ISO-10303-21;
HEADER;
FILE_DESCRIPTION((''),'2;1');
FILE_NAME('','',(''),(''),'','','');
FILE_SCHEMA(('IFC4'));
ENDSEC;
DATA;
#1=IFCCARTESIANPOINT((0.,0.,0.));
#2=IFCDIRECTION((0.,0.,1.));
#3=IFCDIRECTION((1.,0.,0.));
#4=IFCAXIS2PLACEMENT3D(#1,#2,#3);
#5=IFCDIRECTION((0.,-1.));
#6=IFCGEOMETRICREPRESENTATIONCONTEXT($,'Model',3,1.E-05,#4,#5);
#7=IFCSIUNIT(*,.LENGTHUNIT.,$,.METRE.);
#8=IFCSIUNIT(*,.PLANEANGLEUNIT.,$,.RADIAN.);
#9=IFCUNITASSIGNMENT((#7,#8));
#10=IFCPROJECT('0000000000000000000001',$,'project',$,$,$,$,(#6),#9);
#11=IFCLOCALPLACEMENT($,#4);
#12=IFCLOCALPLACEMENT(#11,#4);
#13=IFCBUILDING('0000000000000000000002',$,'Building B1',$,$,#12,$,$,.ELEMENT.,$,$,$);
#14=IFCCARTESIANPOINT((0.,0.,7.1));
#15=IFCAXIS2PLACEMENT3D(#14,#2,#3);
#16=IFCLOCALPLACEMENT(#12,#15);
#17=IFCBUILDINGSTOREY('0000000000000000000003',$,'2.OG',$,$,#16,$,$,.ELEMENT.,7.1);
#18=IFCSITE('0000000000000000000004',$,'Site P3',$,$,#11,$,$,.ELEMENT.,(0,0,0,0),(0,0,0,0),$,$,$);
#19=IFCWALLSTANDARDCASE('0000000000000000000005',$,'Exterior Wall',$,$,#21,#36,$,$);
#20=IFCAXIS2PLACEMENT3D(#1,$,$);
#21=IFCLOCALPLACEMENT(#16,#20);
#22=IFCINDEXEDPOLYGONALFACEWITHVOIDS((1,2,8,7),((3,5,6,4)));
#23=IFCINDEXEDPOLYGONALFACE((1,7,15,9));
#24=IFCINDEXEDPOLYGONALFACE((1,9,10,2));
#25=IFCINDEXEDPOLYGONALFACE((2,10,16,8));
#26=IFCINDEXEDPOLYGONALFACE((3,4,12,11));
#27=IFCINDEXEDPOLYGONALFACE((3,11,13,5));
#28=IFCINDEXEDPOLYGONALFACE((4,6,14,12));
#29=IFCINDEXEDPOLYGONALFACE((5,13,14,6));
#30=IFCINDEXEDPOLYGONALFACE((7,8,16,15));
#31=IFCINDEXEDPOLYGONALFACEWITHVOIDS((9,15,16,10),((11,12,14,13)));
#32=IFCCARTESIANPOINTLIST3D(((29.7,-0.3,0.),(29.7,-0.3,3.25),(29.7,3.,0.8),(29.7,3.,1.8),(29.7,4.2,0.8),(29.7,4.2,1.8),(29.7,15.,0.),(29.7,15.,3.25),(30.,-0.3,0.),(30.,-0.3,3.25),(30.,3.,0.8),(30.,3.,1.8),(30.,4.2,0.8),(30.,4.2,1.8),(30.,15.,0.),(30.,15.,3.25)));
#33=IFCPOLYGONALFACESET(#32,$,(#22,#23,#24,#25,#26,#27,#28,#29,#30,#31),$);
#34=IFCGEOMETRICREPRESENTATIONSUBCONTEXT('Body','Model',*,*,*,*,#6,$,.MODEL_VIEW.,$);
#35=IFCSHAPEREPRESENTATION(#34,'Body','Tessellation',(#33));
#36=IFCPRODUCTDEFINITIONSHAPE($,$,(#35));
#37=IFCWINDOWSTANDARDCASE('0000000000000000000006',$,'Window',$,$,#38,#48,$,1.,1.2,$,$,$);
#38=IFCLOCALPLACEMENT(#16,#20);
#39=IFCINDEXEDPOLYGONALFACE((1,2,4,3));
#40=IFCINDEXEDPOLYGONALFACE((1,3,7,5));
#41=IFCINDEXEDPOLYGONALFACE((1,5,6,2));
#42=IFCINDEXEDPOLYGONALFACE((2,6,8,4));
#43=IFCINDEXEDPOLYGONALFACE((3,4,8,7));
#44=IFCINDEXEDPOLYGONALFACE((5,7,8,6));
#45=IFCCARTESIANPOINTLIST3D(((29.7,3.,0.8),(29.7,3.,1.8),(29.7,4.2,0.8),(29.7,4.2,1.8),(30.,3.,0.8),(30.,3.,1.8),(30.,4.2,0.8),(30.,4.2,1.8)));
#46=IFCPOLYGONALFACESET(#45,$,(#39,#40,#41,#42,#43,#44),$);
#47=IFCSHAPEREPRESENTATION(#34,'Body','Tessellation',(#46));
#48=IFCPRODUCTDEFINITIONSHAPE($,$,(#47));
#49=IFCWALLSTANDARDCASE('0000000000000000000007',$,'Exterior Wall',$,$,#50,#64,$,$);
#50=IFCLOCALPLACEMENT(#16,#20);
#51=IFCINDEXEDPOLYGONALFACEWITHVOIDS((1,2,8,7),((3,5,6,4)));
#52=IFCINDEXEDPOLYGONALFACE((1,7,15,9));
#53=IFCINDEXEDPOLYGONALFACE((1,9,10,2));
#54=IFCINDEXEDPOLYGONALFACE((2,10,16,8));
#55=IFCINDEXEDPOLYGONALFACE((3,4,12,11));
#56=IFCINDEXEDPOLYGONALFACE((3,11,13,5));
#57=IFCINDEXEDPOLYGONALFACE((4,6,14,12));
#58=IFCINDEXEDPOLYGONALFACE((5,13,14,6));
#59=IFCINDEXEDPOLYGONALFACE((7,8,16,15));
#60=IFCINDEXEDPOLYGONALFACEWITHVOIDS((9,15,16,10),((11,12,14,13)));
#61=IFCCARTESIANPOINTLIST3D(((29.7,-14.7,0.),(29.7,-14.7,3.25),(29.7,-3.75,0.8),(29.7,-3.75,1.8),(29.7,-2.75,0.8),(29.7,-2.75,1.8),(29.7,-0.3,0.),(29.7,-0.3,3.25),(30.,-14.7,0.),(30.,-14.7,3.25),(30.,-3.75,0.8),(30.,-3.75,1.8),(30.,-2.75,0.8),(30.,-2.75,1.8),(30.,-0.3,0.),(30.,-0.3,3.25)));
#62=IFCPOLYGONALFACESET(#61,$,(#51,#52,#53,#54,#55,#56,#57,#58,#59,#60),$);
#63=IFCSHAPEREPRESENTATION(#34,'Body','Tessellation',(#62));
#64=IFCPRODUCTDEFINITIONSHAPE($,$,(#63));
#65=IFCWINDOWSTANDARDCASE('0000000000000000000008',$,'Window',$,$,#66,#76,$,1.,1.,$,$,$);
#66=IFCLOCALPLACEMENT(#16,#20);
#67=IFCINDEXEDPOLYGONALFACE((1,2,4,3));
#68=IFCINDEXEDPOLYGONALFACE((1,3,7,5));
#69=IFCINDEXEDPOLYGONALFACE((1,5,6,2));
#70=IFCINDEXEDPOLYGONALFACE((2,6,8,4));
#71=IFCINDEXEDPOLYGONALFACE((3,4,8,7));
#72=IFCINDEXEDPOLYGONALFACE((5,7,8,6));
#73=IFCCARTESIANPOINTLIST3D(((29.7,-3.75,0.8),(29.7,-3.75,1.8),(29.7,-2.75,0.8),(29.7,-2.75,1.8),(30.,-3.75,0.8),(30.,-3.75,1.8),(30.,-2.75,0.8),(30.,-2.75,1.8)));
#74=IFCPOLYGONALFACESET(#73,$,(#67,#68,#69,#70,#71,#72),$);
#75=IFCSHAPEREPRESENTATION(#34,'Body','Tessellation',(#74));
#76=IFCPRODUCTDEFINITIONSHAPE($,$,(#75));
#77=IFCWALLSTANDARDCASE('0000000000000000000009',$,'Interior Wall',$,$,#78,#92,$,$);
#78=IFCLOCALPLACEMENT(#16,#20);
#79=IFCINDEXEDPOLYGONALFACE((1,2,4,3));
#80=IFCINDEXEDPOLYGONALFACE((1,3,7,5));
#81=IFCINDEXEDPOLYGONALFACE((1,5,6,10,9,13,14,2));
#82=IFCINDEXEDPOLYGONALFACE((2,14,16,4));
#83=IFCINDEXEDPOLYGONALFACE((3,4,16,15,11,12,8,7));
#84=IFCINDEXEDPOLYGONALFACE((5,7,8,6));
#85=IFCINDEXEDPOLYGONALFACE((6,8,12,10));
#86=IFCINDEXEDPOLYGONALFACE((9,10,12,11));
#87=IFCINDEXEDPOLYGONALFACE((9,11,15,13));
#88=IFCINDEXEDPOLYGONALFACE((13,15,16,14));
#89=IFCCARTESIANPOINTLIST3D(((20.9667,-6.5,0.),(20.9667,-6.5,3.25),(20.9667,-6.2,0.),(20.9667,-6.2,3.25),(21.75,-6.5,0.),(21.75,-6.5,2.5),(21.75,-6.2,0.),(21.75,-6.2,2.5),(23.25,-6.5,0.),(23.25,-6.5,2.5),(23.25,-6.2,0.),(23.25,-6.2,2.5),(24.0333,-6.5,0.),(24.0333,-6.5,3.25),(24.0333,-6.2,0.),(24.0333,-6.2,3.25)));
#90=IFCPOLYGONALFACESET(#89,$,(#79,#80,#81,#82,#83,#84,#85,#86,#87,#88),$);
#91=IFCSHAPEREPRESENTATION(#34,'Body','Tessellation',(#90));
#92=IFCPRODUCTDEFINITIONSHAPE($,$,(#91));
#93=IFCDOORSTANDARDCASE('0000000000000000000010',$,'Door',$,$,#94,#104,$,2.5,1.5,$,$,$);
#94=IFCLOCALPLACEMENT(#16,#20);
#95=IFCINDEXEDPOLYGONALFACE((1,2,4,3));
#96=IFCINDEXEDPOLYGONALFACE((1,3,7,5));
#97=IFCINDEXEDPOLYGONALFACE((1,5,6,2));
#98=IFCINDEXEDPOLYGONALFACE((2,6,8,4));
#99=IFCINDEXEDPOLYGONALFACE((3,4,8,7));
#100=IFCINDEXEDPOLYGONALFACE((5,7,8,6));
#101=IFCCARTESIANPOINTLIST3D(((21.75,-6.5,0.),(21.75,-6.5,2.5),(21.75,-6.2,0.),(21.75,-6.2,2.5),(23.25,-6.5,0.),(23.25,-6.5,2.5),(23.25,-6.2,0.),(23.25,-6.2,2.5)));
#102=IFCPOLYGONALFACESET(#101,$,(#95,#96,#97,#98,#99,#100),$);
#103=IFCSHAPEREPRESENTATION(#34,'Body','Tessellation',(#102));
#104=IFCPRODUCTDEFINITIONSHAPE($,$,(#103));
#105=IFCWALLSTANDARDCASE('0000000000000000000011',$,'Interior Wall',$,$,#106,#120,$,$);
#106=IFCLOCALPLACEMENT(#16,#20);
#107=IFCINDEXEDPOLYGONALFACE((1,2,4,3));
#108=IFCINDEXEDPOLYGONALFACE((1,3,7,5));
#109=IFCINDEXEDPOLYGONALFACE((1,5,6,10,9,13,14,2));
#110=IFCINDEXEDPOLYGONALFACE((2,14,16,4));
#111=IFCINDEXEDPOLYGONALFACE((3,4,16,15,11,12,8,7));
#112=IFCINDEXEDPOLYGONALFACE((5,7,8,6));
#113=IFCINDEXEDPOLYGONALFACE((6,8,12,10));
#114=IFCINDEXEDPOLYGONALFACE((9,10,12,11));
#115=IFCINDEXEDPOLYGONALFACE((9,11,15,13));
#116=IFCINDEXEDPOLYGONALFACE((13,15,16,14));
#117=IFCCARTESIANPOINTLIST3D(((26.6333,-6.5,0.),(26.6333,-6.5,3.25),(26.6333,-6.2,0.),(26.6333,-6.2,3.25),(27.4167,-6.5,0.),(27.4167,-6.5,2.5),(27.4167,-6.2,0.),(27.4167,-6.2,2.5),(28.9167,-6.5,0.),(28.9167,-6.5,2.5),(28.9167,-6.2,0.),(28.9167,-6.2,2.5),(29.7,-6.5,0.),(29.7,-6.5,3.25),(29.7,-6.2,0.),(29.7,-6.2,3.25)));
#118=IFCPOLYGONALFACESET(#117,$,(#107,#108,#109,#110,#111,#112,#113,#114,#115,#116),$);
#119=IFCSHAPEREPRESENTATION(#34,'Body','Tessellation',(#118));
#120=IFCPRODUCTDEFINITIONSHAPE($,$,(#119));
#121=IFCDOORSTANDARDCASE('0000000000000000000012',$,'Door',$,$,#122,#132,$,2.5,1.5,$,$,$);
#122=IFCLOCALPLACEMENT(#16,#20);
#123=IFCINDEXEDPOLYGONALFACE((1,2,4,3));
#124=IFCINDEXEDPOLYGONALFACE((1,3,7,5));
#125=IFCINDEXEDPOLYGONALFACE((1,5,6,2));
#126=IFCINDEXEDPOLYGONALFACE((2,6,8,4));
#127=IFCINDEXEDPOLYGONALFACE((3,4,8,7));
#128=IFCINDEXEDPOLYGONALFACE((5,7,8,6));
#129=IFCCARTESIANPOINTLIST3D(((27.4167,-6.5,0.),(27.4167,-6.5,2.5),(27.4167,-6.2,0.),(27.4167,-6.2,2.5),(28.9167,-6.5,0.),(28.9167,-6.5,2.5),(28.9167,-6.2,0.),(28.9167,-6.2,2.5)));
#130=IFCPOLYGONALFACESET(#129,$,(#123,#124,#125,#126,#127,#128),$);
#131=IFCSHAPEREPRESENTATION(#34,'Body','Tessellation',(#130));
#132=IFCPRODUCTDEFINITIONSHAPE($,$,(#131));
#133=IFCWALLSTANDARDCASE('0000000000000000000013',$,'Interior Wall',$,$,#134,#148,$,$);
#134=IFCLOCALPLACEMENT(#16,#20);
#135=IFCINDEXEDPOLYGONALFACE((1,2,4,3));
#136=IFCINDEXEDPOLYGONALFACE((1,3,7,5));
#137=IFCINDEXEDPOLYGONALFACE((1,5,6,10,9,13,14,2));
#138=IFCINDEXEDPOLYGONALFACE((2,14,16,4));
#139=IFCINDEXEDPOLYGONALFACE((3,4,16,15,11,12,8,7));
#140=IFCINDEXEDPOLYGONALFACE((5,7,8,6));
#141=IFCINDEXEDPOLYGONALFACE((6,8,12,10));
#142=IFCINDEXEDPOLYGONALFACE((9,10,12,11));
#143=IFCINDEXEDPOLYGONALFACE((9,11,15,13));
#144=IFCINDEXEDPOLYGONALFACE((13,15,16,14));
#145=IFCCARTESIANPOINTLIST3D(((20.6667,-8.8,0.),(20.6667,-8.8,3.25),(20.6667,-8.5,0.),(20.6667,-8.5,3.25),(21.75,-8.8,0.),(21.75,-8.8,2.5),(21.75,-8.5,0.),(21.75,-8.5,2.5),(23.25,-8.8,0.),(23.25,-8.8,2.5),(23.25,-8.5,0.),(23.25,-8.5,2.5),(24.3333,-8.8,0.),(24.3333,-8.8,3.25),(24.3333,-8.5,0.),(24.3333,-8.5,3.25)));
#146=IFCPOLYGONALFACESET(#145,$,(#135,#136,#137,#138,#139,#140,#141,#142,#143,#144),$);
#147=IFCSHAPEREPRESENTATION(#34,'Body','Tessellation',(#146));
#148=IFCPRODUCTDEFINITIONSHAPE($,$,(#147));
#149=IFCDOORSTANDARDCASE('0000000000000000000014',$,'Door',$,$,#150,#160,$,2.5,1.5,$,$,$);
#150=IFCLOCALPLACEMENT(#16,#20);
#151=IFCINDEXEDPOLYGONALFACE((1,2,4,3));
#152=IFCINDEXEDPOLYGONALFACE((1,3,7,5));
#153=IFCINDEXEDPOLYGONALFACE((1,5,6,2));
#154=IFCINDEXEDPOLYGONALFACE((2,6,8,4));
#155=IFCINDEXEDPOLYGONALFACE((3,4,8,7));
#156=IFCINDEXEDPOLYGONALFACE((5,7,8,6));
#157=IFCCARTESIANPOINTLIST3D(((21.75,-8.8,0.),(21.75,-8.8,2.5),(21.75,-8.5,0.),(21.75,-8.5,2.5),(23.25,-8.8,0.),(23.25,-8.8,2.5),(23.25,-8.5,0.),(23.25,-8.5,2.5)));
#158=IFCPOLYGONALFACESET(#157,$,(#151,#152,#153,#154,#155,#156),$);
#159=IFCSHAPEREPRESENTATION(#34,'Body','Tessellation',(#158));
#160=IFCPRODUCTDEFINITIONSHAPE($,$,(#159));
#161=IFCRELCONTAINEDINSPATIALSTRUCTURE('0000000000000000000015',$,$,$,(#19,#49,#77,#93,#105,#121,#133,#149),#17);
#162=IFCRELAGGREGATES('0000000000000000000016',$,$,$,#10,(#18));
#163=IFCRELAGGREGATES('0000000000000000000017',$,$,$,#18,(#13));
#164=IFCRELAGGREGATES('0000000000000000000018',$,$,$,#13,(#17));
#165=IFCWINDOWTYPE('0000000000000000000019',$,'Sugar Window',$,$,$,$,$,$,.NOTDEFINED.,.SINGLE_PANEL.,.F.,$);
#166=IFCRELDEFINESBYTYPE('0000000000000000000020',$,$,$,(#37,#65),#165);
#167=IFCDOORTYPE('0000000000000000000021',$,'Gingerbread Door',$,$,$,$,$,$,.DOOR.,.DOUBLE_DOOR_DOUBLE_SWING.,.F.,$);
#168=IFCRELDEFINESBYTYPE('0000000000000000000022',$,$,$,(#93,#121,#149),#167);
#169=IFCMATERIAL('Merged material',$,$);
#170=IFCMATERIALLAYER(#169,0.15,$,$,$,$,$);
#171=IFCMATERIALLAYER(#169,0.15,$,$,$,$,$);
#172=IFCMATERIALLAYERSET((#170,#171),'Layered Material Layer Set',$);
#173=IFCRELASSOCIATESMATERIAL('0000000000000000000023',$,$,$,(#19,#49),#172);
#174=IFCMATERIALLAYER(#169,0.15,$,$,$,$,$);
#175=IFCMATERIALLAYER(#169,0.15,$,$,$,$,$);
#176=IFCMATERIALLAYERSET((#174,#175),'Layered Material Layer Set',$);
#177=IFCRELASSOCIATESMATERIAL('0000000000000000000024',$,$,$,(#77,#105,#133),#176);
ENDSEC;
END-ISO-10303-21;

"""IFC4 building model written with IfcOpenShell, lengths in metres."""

from ifc_helpers import new_model, si_unit, direction, frame, origin_with_axes, place, context, subcontext, project, spatial, polyline, outline, extrude, source, transform, mapped, material, layer, layer_set, layer_usage, type_object, element, fill, save


model = new_model("IFC4")

# Units and contexts
model_context = context("Model", 3, precision=1e-05, world=origin_with_axes(), true_north=direction((0.0, -1.0)))
body_context = subcontext(model_context, "Body", "Model", "MODEL_VIEW")
ifc_project = project(units=[si_unit("LENGTHUNIT", "METRE"), si_unit("PLANEANGLEUNIT", "RADIAN")], contexts=[model_context])

# Site, building, storey
site_placement = place(None, origin_with_axes())
site = spatial("IfcSite", under=ifc_project, at=site_placement, Name="Site P3", CompositionType="ELEMENT", RefLatitude=(0, 0, 0, 0), RefLongitude=(0, 0, 0, 0))
building_placement = place(site_placement, origin_with_axes())
building = spatial("IfcBuilding", under=site, at=building_placement, Name="Building B1", CompositionType="ELEMENT")
storey_placement = place(building_placement, frame((0.0, 0.0, 7.1), z_axis=(0.0, 0.0, 1.0), x_axis=(1.0, 0.0, 0.0)))
storey = spatial("IfcBuildingStorey", under=building, at=storey_placement, Name="2.OG", CompositionType="ELEMENT", Elevation=7.1)

# Walls, openings, windows
ifc_material = material(Name="Merged material")
ifc_layer_1 = layer(ifc_material, 0.15)
ifc_layer_2 = layer(ifc_material, 0.15)
ifc_layer_set_1 = layer_set([ifc_layer_1, ifc_layer_2], Name="Layered Material Layer Set")
ifc_layer_usage_1 = layer_usage(ifc_layer_set_1, "AXIS2", "POSITIVE", -0.15)
wall_1_placement = place(storey_placement, frame((29.85, -0.3, 0.0), z_axis=(0.0, 0.0, 1.0), x_axis=(0.0, 1.0, 0.0)))
wall_1 = element("IfcWallStandardCase", 1, at=wall_1_placement, inside=storey, material=ifc_layer_usage_1, Name="Exterior Wall", context=body_context, shape_type="SweptSolid", body=[
    extrude(outline(polyline([(0.0, 0.15), (15.3, 0.15), (15.3, -0.15), (0.0, -0.15), (0.0, 0.15)])), origin_with_axes(), (0.0, 0.0, 1.0), 3.25),
])
opening_1_placement = place(wall_1_placement, frame((3.3, 0.0, 0.8), z_axis=(0.0, 0.0, 1.0), x_axis=(1.0, 0.0, 0.0)))
opening_1 = element("IfcOpeningStandardCase", 2, at=opening_1_placement, cuts=wall_1, context=body_context, shape_type="SweptSolid", body=[
    extrude(outline(polyline([(0.0, 0.0), (0.0, 1.2), (1.0, 1.2), (1.0, 0.0), (0.0, 0.0)])), frame((0.0, -0.15, 0.0), z_axis=(0.0, 1.0, 0.0), x_axis=(0.0, 0.0, 1.0)), (0.0, 0.0, 1.0), 0.3),
])
window_type = type_object("IfcWindowType", Name="Sugar Window", ParameterTakesPrecedence=False, PartitioningType="SINGLE_PANEL", PredefinedType="NOTDEFINED")
shared_shape_1 = source(origin_with_axes(), body_context, "Body", "SweptSolid", [
    extrude(outline(polyline([(0.0, 0.0), (0.0, 1.2), (1.0, 1.2), (1.0, 0.0), (0.0, 0.0)])), frame((0.0, -0.15, 0.0), z_axis=(0.0, 1.0, 0.0), x_axis=(0.0, 0.0, 1.0)), (0.0, 0.0, 1.0), 0.3),
])
window_1_placement = place(opening_1_placement, origin_with_axes())
window_1 = element("IfcWindowStandardCase", 3, at=window_1_placement, type_object=window_type, Name="Window", OverallHeight=1.0, OverallWidth=1.2, context=body_context, shape_type="MappedRepresentation", body=[
    mapped(shared_shape_1, transform((0.0, 0.0, 0.0))),
])
fill(opening_1, window_1)
wall_2_placement = place(storey_placement, frame((29.85, -14.7, 0.0), z_axis=(0.0, 0.0, 1.0), x_axis=(0.0, 1.0, 0.0)))
wall_2 = element("IfcWallStandardCase", 4, at=wall_2_placement, inside=storey, material=ifc_layer_usage_1, Name="Exterior Wall", context=body_context, shape_type="SweptSolid", body=[
    extrude(outline(polyline([(0.0, 0.15), (14.4, 0.15), (14.4, -0.15), (0.0, -0.15), (0.0, 0.15)])), origin_with_axes(), (0.0, 0.0, 1.0), 3.25),
])
opening_2_placement = place(wall_2_placement, frame((10.95, 0.0, 0.8), z_axis=(0.0, 0.0, 1.0), x_axis=(1.0, 0.0, 0.0)))
opening_2 = element("IfcOpeningStandardCase", 5, at=opening_2_placement, cuts=wall_2, context=body_context, shape_type="SweptSolid", body=[
    extrude(outline(polyline([(0.0, 0.0), (0.0, 1.0), (1.0, 1.0), (1.0, 0.0), (0.0, 0.0)])), frame((0.0, -0.15, 0.0), z_axis=(0.0, 1.0, 0.0), x_axis=(0.0, 0.0, 1.0)), (0.0, 0.0, 1.0), 0.3),
])
shared_shape_2 = source(origin_with_axes(), body_context, "Body", "SweptSolid", [
    extrude(outline(polyline([(0.0, 0.0), (0.0, 1.0), (1.0, 1.0), (1.0, 0.0), (0.0, 0.0)])), frame((0.0, -0.15, 0.0), z_axis=(0.0, 1.0, 0.0), x_axis=(0.0, 0.0, 1.0)), (0.0, 0.0, 1.0), 0.3),
])
window_2_placement = place(opening_2_placement, origin_with_axes())
window_2 = element("IfcWindowStandardCase", 6, at=window_2_placement, type_object=window_type, Name="Window", OverallHeight=1.0, OverallWidth=1.0, context=body_context, shape_type="MappedRepresentation", body=[
    mapped(shared_shape_2, transform((0.0, 0.0, 0.0))),
])
fill(opening_2, window_2)

# Walls, openings, doors
ifc_layer_3 = layer(ifc_material, 0.15)
ifc_layer_4 = layer(ifc_material, 0.15)
ifc_layer_set_2 = layer_set([ifc_layer_3, ifc_layer_4], Name="Layered Material Layer Set")
ifc_layer_usage_2 = layer_usage(ifc_layer_set_2, "AXIS2", "POSITIVE", -0.15)
wall_3_placement = place(storey_placement, frame((20.9667, -6.35, 0.0), z_axis=(0.0, 0.0, 1.0), x_axis=(1.0, 0.0, 0.0)))
wall_3 = element("IfcWallStandardCase", 7, at=wall_3_placement, inside=storey, material=ifc_layer_usage_2, Name="Interior Wall", context=body_context, shape_type="SweptSolid", body=[
    extrude(outline(polyline([(0.0, 0.15), (3.0667, 0.15), (3.0667, -0.15), (0.0, -0.15), (0.0, 0.15)])), origin_with_axes(), (0.0, 0.0, 1.0), 3.25),
])
opening_3_placement = place(wall_3_placement, frame((0.7833, 0.0, 0.0), z_axis=(0.0, 0.0, 1.0), x_axis=(1.0, 0.0, 0.0)))
opening_3 = element("IfcOpeningStandardCase", 8, at=opening_3_placement, cuts=wall_3, context=body_context, shape_type="SweptSolid", body=[
    extrude(outline(polyline([(0.0, 0.0), (0.0, 1.5), (2.5, 1.5), (2.5, 0.0), (0.0, 0.0)])), frame((0.0, -0.15, 0.0), z_axis=(0.0, 1.0, 0.0), x_axis=(0.0, 0.0, 1.0)), (0.0, 0.0, 1.0), 0.3),
])
door_type = type_object("IfcDoorType", Name="Gingerbread Door", OperationType="DOUBLE_DOOR_DOUBLE_SWING", ParameterTakesPrecedence=False, PredefinedType="DOOR")
shared_shape_3 = source(origin_with_axes(), body_context, "Body", "SweptSolid", [
    extrude(outline(polyline([(0.0, 0.0), (0.0, 1.5), (2.5, 1.5), (2.5, 0.0), (0.0, 0.0)])), frame((0.0, -0.15, 0.0), z_axis=(0.0, 1.0, 0.0), x_axis=(0.0, 0.0, 1.0)), (0.0, 0.0, 1.0), 0.3),
])
door_1_placement = place(opening_3_placement, origin_with_axes())
door_1 = element("IfcDoorStandardCase", 9, at=door_1_placement, inside=storey, type_object=door_type, Name="Door", OverallHeight=2.5, OverallWidth=1.5, context=body_context, shape_type="MappedRepresentation", body=[
    mapped(shared_shape_3, transform((0.0, 0.0, 0.0))),
])
fill(opening_3, door_1)
wall_4_placement = place(storey_placement, frame((26.6333, -6.35, 0.0), z_axis=(0.0, 0.0, 1.0), x_axis=(1.0, 0.0, 0.0)))
wall_4 = element("IfcWallStandardCase", 10, at=wall_4_placement, inside=storey, material=ifc_layer_usage_2, Name="Interior Wall", context=body_context, shape_type="SweptSolid", body=[
    extrude(outline(polyline([(0.0, 0.15), (3.0667, 0.15), (3.0667, -0.15), (0.0, -0.15), (0.0, 0.15)])), origin_with_axes(), (0.0, 0.0, 1.0), 3.25),
])
opening_4_placement = place(wall_4_placement, frame((0.7833, 0.0, 0.0), z_axis=(0.0, 0.0, 1.0), x_axis=(1.0, 0.0, 0.0)))
opening_4 = element("IfcOpeningStandardCase", 11, at=opening_4_placement, cuts=wall_4, context=body_context, shape_type="SweptSolid", body=[
    extrude(outline(polyline([(0.0, 0.0), (0.0, 1.5), (2.5, 1.5), (2.5, 0.0), (0.0, 0.0)])), frame((0.0, -0.15, 0.0), z_axis=(0.0, 1.0, 0.0), x_axis=(0.0, 0.0, 1.0)), (0.0, 0.0, 1.0), 0.3),
])
door_2_placement = place(opening_4_placement, origin_with_axes())
door_2 = element("IfcDoorStandardCase", 12, at=door_2_placement, inside=storey, type_object=door_type, Name="Door", OverallHeight=2.5, OverallWidth=1.5, context=body_context, shape_type="MappedRepresentation", body=[
    mapped(shared_shape_3, transform((0.0, 0.0, 0.0))),
])
fill(opening_4, door_2)
wall_5_placement = place(storey_placement, frame((20.6667, -8.65, 0.0), z_axis=(0.0, 0.0, 1.0), x_axis=(1.0, 0.0, 0.0)))
wall_5 = element("IfcWallStandardCase", 13, at=wall_5_placement, inside=storey, material=ifc_layer_usage_2, Name="Interior Wall", context=body_context, shape_type="SweptSolid", body=[
    extrude(outline(polyline([(0.0, 0.15), (3.6667, 0.15), (3.6667, -0.15), (0.0, -0.15), (0.0, 0.15)])), origin_with_axes(), (0.0, 0.0, 1.0), 3.25),
])
opening_5_placement = place(wall_5_placement, frame((1.0833, 0.0, 0.0), z_axis=(0.0, 0.0, 1.0), x_axis=(1.0, 0.0, 0.0)))
opening_5 = element("IfcOpeningStandardCase", 14, at=opening_5_placement, cuts=wall_5, context=body_context, shape_type="SweptSolid", body=[
    extrude(outline(polyline([(0.0, 0.0), (0.0, 1.5), (2.5, 1.5), (2.5, 0.0), (0.0, 0.0)])), frame((0.0, -0.15, 0.0), z_axis=(0.0, 1.0, 0.0), x_axis=(0.0, 0.0, 1.0)), (0.0, 0.0, 1.0), 0.3),
])
door_3_placement = place(opening_5_placement, origin_with_axes())
door_3 = element("IfcDoorStandardCase", 15, at=door_3_placement, inside=storey, type_object=door_type, Name="Door", OverallHeight=2.5, OverallWidth=1.5, context=body_context, shape_type="MappedRepresentation", body=[
    mapped(shared_shape_3, transform((0.0, 0.0, 0.0))),
])
fill(opening_5, door_3)

save(model, "model.ifc")
